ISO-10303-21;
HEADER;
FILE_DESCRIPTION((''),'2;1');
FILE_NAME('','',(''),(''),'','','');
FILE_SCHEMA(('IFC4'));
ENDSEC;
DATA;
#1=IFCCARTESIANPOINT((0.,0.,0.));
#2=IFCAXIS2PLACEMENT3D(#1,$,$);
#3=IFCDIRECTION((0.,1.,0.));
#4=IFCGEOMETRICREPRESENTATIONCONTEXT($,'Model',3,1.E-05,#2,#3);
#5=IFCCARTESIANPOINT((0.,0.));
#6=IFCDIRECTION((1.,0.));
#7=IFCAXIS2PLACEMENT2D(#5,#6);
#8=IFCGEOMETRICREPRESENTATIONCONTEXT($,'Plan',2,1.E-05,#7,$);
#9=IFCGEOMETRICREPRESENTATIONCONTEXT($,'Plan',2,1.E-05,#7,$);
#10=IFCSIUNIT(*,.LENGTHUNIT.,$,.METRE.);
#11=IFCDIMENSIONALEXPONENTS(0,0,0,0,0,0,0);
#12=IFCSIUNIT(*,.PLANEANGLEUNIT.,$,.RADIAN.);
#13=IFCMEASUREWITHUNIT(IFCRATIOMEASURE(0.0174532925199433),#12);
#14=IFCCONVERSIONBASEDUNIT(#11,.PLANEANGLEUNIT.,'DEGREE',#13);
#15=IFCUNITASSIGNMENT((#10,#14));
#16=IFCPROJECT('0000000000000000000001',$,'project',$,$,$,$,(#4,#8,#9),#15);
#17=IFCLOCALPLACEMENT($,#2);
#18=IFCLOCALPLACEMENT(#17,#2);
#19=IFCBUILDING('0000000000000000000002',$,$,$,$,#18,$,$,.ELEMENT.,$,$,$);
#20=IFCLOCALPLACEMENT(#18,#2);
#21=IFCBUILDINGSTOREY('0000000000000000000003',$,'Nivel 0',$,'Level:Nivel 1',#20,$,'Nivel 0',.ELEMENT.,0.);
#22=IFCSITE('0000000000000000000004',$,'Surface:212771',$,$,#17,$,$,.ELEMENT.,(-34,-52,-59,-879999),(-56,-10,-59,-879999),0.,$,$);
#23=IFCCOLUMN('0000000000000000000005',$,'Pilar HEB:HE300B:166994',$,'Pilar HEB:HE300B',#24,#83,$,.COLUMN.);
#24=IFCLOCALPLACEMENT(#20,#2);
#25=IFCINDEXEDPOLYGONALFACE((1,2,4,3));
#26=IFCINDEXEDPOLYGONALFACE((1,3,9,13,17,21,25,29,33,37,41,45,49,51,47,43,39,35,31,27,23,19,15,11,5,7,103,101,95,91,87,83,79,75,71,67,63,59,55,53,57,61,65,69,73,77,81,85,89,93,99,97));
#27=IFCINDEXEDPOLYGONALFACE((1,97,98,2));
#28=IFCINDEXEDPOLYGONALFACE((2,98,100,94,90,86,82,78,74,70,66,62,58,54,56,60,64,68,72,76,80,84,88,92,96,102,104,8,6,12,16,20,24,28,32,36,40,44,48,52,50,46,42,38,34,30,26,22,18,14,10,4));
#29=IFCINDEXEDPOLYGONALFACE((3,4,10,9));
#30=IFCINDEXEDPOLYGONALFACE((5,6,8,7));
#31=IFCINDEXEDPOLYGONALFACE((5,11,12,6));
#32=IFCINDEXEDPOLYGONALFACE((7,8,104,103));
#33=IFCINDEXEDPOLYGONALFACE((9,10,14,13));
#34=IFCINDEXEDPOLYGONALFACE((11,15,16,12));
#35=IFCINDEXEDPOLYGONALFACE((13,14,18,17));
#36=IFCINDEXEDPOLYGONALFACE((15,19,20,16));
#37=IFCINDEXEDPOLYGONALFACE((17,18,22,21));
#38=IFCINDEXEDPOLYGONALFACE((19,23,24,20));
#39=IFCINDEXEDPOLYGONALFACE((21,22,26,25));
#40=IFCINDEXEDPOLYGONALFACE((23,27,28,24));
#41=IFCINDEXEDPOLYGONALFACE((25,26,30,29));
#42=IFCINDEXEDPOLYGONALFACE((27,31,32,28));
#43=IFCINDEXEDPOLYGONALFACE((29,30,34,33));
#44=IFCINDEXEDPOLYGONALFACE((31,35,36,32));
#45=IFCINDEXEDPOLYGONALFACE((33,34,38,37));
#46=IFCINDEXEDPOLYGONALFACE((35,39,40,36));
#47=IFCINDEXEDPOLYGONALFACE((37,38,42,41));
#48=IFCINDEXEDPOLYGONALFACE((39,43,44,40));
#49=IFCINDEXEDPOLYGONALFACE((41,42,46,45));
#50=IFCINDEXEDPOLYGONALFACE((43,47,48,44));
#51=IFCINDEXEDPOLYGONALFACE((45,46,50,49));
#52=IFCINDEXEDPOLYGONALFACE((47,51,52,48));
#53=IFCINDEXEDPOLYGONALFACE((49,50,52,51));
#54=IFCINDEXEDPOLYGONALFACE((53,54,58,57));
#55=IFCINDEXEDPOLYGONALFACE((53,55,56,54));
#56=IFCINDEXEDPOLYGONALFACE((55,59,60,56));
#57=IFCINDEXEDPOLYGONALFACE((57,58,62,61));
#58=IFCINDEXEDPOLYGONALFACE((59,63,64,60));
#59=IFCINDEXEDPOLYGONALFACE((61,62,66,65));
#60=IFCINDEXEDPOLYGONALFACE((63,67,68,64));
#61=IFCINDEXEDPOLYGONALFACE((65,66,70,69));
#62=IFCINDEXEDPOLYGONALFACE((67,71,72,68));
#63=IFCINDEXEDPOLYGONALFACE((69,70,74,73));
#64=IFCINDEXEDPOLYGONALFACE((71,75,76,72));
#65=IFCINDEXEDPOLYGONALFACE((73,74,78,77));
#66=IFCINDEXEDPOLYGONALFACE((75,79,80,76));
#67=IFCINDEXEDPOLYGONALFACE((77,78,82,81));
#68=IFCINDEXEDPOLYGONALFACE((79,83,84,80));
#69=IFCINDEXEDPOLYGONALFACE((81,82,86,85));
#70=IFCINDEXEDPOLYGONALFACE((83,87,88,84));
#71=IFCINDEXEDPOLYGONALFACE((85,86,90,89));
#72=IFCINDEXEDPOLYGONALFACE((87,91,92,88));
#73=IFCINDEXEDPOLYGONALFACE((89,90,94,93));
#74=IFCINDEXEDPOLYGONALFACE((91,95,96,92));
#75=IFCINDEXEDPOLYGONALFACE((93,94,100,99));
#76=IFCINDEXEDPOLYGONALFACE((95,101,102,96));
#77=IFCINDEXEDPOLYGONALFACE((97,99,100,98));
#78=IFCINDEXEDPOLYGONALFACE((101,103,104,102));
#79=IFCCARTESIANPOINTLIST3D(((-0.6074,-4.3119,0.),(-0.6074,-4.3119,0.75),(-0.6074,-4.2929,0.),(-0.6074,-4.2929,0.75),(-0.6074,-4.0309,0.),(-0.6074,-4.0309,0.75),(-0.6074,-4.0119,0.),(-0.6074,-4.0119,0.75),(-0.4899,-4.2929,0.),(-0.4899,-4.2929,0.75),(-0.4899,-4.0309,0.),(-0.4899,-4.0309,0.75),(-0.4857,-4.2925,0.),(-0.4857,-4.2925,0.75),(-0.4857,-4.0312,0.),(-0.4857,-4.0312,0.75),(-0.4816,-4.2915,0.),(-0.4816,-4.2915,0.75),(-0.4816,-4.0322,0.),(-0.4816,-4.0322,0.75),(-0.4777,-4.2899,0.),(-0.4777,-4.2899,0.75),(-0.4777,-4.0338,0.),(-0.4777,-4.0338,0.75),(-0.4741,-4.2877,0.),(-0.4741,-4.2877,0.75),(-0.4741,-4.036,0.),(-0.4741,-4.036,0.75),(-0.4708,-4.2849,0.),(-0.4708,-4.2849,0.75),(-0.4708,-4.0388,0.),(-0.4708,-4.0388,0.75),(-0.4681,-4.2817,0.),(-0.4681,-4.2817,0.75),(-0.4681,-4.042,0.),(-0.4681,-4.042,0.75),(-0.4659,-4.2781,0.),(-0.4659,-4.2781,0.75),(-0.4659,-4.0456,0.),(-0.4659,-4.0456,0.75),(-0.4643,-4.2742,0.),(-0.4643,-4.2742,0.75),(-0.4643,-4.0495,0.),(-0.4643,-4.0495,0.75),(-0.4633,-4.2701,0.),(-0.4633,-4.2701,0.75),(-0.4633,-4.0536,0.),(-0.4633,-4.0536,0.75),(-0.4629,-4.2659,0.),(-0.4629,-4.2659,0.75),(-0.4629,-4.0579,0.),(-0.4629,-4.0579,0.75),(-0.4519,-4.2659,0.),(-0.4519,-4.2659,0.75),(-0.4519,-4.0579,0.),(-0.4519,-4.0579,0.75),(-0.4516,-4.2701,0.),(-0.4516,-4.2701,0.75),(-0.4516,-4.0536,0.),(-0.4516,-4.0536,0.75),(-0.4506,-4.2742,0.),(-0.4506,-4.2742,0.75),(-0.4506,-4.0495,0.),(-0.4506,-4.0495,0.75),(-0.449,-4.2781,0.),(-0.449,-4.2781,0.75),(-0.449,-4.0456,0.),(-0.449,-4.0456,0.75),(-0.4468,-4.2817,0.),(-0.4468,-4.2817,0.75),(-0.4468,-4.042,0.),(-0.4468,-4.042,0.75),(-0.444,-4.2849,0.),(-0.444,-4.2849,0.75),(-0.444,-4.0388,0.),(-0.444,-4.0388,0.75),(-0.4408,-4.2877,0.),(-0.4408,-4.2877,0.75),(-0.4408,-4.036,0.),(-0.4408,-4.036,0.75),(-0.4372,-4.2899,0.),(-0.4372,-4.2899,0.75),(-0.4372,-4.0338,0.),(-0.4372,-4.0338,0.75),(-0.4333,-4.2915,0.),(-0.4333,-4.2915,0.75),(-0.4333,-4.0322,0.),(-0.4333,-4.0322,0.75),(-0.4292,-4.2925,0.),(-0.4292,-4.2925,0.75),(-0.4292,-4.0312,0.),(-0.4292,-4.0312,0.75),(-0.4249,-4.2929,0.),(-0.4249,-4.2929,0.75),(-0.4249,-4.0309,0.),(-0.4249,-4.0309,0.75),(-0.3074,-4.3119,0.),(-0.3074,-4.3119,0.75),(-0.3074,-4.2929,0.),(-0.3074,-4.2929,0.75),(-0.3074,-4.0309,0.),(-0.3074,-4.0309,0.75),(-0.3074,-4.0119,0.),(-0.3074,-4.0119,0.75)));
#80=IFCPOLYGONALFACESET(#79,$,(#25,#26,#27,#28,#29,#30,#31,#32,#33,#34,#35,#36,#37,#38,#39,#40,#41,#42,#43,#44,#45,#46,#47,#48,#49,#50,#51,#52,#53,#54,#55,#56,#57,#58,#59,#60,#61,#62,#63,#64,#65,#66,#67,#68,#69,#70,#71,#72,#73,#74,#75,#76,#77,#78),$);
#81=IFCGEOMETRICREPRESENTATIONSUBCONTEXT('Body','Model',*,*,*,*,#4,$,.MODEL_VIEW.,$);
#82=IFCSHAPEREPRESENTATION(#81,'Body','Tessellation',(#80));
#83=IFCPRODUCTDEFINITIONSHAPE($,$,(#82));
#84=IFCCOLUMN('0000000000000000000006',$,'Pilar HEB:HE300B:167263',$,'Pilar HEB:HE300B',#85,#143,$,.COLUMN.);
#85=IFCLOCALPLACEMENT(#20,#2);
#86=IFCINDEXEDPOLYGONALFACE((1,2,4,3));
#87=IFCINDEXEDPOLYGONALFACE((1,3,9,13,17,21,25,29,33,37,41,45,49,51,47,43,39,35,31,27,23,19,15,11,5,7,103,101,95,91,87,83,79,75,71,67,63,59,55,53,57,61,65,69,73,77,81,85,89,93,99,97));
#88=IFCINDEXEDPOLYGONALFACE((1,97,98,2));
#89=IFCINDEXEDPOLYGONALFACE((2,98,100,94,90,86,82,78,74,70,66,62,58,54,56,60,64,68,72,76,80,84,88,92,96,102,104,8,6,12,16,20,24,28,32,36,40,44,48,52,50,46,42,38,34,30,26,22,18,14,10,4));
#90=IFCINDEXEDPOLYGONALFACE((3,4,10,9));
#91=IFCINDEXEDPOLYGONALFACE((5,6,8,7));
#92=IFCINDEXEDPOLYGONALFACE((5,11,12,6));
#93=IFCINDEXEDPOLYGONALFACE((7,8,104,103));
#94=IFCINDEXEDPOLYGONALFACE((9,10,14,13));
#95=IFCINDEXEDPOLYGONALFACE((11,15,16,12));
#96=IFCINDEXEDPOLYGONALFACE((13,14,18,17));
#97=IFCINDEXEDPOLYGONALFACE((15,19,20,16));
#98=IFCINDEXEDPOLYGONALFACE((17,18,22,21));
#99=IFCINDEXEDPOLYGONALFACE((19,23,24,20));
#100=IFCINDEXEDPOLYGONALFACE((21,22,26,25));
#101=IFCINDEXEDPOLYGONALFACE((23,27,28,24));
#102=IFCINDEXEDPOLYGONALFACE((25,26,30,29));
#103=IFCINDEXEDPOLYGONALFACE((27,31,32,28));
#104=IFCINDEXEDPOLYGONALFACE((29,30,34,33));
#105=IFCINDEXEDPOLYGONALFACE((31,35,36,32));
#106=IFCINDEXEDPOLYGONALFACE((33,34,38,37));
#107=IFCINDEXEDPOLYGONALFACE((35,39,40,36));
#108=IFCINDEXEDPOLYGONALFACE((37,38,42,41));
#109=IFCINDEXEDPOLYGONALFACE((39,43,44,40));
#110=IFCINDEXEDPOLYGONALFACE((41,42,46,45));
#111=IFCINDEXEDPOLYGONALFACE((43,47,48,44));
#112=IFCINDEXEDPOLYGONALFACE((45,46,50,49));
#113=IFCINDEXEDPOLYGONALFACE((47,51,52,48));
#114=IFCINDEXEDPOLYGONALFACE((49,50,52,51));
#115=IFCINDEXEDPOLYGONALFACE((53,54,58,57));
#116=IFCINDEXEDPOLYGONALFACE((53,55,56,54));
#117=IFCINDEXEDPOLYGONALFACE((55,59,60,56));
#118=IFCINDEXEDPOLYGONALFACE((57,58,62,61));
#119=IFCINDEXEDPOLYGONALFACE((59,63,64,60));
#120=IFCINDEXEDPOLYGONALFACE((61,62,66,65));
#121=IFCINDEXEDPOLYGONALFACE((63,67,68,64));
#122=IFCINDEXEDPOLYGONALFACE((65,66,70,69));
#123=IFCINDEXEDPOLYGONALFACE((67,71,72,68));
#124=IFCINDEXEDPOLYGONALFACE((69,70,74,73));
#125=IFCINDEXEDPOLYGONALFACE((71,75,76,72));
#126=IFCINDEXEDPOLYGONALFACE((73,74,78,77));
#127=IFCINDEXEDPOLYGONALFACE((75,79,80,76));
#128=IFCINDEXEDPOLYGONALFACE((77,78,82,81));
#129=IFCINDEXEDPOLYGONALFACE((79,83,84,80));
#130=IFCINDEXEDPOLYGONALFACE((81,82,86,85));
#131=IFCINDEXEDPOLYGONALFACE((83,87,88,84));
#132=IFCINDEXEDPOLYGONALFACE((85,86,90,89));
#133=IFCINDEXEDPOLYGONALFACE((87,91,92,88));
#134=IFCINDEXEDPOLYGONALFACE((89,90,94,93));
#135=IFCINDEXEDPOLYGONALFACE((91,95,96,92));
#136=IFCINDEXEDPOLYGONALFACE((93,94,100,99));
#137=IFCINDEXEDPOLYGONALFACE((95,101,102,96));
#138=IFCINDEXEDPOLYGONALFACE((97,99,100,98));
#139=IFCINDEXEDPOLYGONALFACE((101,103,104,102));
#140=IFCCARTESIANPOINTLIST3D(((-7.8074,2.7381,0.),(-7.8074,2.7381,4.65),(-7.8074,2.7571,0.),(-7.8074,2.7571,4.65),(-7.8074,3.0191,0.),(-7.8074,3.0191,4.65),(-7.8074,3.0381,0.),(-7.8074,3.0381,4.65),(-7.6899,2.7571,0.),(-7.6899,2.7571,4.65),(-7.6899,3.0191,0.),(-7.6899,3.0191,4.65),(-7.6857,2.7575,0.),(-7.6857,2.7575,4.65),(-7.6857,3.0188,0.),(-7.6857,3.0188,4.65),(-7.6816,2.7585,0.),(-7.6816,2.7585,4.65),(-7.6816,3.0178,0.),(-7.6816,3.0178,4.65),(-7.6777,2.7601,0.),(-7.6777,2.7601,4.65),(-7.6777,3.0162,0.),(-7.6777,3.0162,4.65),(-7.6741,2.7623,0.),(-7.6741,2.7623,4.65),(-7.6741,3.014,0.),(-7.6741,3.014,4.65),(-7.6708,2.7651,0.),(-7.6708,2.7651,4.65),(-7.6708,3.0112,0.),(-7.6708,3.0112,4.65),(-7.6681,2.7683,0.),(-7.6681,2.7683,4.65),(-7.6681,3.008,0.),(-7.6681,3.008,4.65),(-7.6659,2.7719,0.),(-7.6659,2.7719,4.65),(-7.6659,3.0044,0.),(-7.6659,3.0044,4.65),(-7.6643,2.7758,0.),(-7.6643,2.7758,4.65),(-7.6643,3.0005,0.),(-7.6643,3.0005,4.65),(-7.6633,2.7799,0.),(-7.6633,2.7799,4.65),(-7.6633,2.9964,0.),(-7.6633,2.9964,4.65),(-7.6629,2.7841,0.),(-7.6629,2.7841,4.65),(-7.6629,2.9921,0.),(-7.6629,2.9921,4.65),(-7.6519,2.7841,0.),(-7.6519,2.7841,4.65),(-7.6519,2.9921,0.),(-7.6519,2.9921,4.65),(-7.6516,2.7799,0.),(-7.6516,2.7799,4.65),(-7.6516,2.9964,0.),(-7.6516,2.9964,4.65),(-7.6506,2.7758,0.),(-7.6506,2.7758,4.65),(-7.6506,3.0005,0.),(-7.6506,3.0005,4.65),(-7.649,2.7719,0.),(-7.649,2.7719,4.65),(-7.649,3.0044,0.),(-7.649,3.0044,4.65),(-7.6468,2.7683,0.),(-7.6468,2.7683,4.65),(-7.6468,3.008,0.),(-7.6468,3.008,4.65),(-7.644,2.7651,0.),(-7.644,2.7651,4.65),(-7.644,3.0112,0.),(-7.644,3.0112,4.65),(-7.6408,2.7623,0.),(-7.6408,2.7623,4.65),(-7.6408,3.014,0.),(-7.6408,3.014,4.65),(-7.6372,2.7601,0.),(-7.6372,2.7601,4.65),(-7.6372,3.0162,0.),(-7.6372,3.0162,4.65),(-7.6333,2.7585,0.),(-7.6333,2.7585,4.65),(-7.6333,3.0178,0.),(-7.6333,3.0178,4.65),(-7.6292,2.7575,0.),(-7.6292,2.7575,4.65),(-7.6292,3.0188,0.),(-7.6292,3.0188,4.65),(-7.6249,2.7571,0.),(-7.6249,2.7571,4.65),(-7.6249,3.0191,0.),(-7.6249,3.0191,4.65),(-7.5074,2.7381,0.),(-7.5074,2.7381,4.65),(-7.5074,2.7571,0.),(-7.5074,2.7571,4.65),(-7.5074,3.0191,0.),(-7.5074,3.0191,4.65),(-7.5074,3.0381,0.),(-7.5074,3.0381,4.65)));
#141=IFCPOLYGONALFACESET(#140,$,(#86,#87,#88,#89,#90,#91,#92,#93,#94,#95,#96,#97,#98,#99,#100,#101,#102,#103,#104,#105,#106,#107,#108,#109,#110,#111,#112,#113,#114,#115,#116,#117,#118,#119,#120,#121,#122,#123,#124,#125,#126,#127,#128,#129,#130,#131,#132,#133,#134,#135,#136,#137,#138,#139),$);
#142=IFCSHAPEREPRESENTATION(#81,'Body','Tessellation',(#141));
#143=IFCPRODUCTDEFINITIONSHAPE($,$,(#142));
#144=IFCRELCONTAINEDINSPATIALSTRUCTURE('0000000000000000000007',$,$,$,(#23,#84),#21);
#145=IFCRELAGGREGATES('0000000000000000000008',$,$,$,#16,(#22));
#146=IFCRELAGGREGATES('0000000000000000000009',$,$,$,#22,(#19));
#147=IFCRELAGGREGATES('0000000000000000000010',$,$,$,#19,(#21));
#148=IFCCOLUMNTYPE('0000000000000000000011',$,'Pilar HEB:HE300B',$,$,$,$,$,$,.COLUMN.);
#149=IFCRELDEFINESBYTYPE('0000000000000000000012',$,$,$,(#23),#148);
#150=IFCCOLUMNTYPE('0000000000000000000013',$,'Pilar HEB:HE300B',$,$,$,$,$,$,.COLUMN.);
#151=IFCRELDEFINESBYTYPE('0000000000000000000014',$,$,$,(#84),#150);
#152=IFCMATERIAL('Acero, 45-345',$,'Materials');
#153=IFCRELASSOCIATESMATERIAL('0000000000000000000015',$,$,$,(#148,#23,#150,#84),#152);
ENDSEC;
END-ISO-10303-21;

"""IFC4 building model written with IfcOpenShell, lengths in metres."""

from ifc_helpers import new_model, entity, si_unit, converted_unit, direction, frame, origin, origin_2d_with_axis, place, context, subcontext, project, spatial, indexed_curve, outline, extrude, source, transform, mapped, material, type_object, type_shapes, element, save


model = new_model("IFC4")

# Units and contexts
model_context = context("Model", 3, precision=1e-05, world=origin(), true_north=direction((0.0, 1.0, 0.0)))
plan_context_1 = context("Plan", 2, precision=1e-05, world=origin_2d_with_axis())
plan_context_2 = context("Plan", 2, precision=1e-05, world=origin_2d_with_axis())
body_context = subcontext(model_context, "Body", "Model", "MODEL_VIEW")
ifc_project = project(units=[si_unit("LENGTHUNIT", "METRE"), converted_unit("PLANEANGLEUNIT", "DEGREE", entity("IfcRatioMeasure", 0.0174532925199433), si_unit("PLANEANGLEUNIT", "RADIAN"), dimensions=[0, 0, 0, 0, 0, 0, 0])], contexts=[model_context, plan_context_1, plan_context_2])

# Site, building, storey
site_placement = place(None, origin())
site = spatial("IfcSite", under=ifc_project, at=site_placement, Name="Surface:212771", CompositionType="ELEMENT", RefLatitude=(-34, -52, -59, -879999), RefLongitude=(-56, -10, -59, -879999), RefElevation=0.0)
building_placement = place(site_placement, origin())
building = spatial("IfcBuilding", under=site, at=building_placement, CompositionType="ELEMENT")
storey_placement = place(building_placement, origin())
storey = spatial("IfcBuildingStorey", under=building, at=storey_placement, Name="Nivel 0", ObjectType="Level:Nivel 1", LongName="Nivel 0", CompositionType="ELEMENT", Elevation=0.0)

# Columns
ifc_material_1 = material(Name="Acero, 45-345", Category="Materials")
column_type_1 = type_object("IfcColumnType", Name="Pilar HEB:HE300B", PredefinedType="COLUMN", material=ifc_material_1)
shared_shape_1 = source(origin(), body_context, "Body", "SweptSolid", [
    extrude(outline(indexed_curve([(-0.15, -0.15), (-0.131, -0.15), (-0.131, -0.0325), (-0.1307, -0.0283), (-0.1297, -0.0242), (-0.1281, -0.0202), (-0.1258, -0.0166), (-0.1231, -0.0134), (-0.1199, -0.0107), (-0.1163, -0.0084), (-0.1123, -0.0068), (-0.1082, -0.0058), (-0.104, -0.0055), (0.104, -0.0055), (0.1082, -0.0058), (0.1123, -0.0068), (0.1163, -0.0084), (0.1199, -0.0107), (0.1231, -0.0134), (0.1258, -0.0166), (0.1281, -0.0202), (0.1297, -0.0242), (0.1307, -0.0283), (0.131, -0.0325), (0.131, -0.15), (0.15, -0.15), (0.15, 0.15), (0.131, 0.15), (0.131, 0.0325), (0.1307, 0.0283), (0.1297, 0.0242), (0.1281, 0.0202), (0.1258, 0.0166), (0.1231, 0.0134), (0.1199, 0.0107), (0.1163, 0.0084), (0.1123, 0.0068), (0.1082, 0.0058), (0.104, 0.0055), (-0.104, 0.0055), (-0.1082, 0.0058), (-0.1123, 0.0068), (-0.1163, 0.0084), (-0.1199, 0.0107), (-0.1231, 0.0134), (-0.1258, 0.0166), (-0.1281, 0.0202), (-0.1297, 0.0242), (-0.1307, 0.0283), (-0.131, 0.0325), (-0.131, 0.15), (-0.15, 0.15), (-0.15, -0.15)], self_intersect=False)), frame((0.0, 0.0, 0.0), z_axis=(0.0, 0.0, 1.0), x_axis=(0.0, -1.0, 0.0)), (0.0, 0.0, 1.0), 0.75),
])
type_shapes(column_type_1, [shared_shape_1])
for number, where, name in (
    (1, (-0.4574, -4.1619, 0.0), "Pilar HEB:HE300B:166994"),
):
    element("IfcColumn", number, at=place(storey_placement, frame(where)), inside=storey, type_object=column_type_1, material=ifc_material_1, Name=name, ObjectType="Pilar HEB:HE300B", PredefinedType="COLUMN", context=body_context, shape_type="MappedRepresentation", body=[
        mapped(shared_shape_1, transform((0.0, 0.0, 0.0), scale=1.0)),
    ])
column_type_2 = type_object("IfcColumnType", Name="Pilar HEB:HE300B", PredefinedType="COLUMN", material=ifc_material_1)
shared_shape_2 = source(origin(), body_context, "Body", "SweptSolid", [
    extrude(outline(indexed_curve([(-0.15, -0.15), (-0.131, -0.15), (-0.131, -0.0325), (-0.1307, -0.0283), (-0.1297, -0.0242), (-0.1281, -0.0202), (-0.1258, -0.0166), (-0.1231, -0.0134), (-0.1199, -0.0107), (-0.1163, -0.0084), (-0.1123, -0.0068), (-0.1082, -0.0058), (-0.104, -0.0055), (0.104, -0.0055), (0.1082, -0.0058), (0.1123, -0.0068), (0.1163, -0.0084), (0.1199, -0.0107), (0.1231, -0.0134), (0.1258, -0.0166), (0.1281, -0.0202), (0.1297, -0.0242), (0.1307, -0.0283), (0.131, -0.0325), (0.131, -0.15), (0.15, -0.15), (0.15, 0.15), (0.131, 0.15), (0.131, 0.0325), (0.1307, 0.0283), (0.1297, 0.0242), (0.1281, 0.0202), (0.1258, 0.0166), (0.1231, 0.0134), (0.1199, 0.0107), (0.1163, 0.0084), (0.1123, 0.0068), (0.1082, 0.0058), (0.104, 0.0055), (-0.104, 0.0055), (-0.1082, 0.0058), (-0.1123, 0.0068), (-0.1163, 0.0084), (-0.1199, 0.0107), (-0.1231, 0.0134), (-0.1258, 0.0166), (-0.1281, 0.0202), (-0.1297, 0.0242), (-0.1307, 0.0283), (-0.131, 0.0325), (-0.131, 0.15), (-0.15, 0.15), (-0.15, -0.15)], self_intersect=False)), frame((0.0, 0.0, 0.0), z_axis=(0.0, 0.0, 1.0), x_axis=(0.0, -1.0, 0.0)), (0.0, 0.0, 1.0), 4.65),
])
type_shapes(column_type_2, [shared_shape_2])
for number, where, name in (
    (2, (-7.6574, 2.8881, 0.0), "Pilar HEB:HE300B:167263"),
):
    element("IfcColumn", number, at=place(storey_placement, frame(where)), inside=storey, type_object=column_type_2, material=ifc_material_1, Name=name, ObjectType="Pilar HEB:HE300B", PredefinedType="COLUMN", context=body_context, shape_type="MappedRepresentation", body=[
        mapped(shared_shape_2, transform((0.0, 0.0, 0.0), scale=1.0)),
    ])

save(model, "model.ifc")
